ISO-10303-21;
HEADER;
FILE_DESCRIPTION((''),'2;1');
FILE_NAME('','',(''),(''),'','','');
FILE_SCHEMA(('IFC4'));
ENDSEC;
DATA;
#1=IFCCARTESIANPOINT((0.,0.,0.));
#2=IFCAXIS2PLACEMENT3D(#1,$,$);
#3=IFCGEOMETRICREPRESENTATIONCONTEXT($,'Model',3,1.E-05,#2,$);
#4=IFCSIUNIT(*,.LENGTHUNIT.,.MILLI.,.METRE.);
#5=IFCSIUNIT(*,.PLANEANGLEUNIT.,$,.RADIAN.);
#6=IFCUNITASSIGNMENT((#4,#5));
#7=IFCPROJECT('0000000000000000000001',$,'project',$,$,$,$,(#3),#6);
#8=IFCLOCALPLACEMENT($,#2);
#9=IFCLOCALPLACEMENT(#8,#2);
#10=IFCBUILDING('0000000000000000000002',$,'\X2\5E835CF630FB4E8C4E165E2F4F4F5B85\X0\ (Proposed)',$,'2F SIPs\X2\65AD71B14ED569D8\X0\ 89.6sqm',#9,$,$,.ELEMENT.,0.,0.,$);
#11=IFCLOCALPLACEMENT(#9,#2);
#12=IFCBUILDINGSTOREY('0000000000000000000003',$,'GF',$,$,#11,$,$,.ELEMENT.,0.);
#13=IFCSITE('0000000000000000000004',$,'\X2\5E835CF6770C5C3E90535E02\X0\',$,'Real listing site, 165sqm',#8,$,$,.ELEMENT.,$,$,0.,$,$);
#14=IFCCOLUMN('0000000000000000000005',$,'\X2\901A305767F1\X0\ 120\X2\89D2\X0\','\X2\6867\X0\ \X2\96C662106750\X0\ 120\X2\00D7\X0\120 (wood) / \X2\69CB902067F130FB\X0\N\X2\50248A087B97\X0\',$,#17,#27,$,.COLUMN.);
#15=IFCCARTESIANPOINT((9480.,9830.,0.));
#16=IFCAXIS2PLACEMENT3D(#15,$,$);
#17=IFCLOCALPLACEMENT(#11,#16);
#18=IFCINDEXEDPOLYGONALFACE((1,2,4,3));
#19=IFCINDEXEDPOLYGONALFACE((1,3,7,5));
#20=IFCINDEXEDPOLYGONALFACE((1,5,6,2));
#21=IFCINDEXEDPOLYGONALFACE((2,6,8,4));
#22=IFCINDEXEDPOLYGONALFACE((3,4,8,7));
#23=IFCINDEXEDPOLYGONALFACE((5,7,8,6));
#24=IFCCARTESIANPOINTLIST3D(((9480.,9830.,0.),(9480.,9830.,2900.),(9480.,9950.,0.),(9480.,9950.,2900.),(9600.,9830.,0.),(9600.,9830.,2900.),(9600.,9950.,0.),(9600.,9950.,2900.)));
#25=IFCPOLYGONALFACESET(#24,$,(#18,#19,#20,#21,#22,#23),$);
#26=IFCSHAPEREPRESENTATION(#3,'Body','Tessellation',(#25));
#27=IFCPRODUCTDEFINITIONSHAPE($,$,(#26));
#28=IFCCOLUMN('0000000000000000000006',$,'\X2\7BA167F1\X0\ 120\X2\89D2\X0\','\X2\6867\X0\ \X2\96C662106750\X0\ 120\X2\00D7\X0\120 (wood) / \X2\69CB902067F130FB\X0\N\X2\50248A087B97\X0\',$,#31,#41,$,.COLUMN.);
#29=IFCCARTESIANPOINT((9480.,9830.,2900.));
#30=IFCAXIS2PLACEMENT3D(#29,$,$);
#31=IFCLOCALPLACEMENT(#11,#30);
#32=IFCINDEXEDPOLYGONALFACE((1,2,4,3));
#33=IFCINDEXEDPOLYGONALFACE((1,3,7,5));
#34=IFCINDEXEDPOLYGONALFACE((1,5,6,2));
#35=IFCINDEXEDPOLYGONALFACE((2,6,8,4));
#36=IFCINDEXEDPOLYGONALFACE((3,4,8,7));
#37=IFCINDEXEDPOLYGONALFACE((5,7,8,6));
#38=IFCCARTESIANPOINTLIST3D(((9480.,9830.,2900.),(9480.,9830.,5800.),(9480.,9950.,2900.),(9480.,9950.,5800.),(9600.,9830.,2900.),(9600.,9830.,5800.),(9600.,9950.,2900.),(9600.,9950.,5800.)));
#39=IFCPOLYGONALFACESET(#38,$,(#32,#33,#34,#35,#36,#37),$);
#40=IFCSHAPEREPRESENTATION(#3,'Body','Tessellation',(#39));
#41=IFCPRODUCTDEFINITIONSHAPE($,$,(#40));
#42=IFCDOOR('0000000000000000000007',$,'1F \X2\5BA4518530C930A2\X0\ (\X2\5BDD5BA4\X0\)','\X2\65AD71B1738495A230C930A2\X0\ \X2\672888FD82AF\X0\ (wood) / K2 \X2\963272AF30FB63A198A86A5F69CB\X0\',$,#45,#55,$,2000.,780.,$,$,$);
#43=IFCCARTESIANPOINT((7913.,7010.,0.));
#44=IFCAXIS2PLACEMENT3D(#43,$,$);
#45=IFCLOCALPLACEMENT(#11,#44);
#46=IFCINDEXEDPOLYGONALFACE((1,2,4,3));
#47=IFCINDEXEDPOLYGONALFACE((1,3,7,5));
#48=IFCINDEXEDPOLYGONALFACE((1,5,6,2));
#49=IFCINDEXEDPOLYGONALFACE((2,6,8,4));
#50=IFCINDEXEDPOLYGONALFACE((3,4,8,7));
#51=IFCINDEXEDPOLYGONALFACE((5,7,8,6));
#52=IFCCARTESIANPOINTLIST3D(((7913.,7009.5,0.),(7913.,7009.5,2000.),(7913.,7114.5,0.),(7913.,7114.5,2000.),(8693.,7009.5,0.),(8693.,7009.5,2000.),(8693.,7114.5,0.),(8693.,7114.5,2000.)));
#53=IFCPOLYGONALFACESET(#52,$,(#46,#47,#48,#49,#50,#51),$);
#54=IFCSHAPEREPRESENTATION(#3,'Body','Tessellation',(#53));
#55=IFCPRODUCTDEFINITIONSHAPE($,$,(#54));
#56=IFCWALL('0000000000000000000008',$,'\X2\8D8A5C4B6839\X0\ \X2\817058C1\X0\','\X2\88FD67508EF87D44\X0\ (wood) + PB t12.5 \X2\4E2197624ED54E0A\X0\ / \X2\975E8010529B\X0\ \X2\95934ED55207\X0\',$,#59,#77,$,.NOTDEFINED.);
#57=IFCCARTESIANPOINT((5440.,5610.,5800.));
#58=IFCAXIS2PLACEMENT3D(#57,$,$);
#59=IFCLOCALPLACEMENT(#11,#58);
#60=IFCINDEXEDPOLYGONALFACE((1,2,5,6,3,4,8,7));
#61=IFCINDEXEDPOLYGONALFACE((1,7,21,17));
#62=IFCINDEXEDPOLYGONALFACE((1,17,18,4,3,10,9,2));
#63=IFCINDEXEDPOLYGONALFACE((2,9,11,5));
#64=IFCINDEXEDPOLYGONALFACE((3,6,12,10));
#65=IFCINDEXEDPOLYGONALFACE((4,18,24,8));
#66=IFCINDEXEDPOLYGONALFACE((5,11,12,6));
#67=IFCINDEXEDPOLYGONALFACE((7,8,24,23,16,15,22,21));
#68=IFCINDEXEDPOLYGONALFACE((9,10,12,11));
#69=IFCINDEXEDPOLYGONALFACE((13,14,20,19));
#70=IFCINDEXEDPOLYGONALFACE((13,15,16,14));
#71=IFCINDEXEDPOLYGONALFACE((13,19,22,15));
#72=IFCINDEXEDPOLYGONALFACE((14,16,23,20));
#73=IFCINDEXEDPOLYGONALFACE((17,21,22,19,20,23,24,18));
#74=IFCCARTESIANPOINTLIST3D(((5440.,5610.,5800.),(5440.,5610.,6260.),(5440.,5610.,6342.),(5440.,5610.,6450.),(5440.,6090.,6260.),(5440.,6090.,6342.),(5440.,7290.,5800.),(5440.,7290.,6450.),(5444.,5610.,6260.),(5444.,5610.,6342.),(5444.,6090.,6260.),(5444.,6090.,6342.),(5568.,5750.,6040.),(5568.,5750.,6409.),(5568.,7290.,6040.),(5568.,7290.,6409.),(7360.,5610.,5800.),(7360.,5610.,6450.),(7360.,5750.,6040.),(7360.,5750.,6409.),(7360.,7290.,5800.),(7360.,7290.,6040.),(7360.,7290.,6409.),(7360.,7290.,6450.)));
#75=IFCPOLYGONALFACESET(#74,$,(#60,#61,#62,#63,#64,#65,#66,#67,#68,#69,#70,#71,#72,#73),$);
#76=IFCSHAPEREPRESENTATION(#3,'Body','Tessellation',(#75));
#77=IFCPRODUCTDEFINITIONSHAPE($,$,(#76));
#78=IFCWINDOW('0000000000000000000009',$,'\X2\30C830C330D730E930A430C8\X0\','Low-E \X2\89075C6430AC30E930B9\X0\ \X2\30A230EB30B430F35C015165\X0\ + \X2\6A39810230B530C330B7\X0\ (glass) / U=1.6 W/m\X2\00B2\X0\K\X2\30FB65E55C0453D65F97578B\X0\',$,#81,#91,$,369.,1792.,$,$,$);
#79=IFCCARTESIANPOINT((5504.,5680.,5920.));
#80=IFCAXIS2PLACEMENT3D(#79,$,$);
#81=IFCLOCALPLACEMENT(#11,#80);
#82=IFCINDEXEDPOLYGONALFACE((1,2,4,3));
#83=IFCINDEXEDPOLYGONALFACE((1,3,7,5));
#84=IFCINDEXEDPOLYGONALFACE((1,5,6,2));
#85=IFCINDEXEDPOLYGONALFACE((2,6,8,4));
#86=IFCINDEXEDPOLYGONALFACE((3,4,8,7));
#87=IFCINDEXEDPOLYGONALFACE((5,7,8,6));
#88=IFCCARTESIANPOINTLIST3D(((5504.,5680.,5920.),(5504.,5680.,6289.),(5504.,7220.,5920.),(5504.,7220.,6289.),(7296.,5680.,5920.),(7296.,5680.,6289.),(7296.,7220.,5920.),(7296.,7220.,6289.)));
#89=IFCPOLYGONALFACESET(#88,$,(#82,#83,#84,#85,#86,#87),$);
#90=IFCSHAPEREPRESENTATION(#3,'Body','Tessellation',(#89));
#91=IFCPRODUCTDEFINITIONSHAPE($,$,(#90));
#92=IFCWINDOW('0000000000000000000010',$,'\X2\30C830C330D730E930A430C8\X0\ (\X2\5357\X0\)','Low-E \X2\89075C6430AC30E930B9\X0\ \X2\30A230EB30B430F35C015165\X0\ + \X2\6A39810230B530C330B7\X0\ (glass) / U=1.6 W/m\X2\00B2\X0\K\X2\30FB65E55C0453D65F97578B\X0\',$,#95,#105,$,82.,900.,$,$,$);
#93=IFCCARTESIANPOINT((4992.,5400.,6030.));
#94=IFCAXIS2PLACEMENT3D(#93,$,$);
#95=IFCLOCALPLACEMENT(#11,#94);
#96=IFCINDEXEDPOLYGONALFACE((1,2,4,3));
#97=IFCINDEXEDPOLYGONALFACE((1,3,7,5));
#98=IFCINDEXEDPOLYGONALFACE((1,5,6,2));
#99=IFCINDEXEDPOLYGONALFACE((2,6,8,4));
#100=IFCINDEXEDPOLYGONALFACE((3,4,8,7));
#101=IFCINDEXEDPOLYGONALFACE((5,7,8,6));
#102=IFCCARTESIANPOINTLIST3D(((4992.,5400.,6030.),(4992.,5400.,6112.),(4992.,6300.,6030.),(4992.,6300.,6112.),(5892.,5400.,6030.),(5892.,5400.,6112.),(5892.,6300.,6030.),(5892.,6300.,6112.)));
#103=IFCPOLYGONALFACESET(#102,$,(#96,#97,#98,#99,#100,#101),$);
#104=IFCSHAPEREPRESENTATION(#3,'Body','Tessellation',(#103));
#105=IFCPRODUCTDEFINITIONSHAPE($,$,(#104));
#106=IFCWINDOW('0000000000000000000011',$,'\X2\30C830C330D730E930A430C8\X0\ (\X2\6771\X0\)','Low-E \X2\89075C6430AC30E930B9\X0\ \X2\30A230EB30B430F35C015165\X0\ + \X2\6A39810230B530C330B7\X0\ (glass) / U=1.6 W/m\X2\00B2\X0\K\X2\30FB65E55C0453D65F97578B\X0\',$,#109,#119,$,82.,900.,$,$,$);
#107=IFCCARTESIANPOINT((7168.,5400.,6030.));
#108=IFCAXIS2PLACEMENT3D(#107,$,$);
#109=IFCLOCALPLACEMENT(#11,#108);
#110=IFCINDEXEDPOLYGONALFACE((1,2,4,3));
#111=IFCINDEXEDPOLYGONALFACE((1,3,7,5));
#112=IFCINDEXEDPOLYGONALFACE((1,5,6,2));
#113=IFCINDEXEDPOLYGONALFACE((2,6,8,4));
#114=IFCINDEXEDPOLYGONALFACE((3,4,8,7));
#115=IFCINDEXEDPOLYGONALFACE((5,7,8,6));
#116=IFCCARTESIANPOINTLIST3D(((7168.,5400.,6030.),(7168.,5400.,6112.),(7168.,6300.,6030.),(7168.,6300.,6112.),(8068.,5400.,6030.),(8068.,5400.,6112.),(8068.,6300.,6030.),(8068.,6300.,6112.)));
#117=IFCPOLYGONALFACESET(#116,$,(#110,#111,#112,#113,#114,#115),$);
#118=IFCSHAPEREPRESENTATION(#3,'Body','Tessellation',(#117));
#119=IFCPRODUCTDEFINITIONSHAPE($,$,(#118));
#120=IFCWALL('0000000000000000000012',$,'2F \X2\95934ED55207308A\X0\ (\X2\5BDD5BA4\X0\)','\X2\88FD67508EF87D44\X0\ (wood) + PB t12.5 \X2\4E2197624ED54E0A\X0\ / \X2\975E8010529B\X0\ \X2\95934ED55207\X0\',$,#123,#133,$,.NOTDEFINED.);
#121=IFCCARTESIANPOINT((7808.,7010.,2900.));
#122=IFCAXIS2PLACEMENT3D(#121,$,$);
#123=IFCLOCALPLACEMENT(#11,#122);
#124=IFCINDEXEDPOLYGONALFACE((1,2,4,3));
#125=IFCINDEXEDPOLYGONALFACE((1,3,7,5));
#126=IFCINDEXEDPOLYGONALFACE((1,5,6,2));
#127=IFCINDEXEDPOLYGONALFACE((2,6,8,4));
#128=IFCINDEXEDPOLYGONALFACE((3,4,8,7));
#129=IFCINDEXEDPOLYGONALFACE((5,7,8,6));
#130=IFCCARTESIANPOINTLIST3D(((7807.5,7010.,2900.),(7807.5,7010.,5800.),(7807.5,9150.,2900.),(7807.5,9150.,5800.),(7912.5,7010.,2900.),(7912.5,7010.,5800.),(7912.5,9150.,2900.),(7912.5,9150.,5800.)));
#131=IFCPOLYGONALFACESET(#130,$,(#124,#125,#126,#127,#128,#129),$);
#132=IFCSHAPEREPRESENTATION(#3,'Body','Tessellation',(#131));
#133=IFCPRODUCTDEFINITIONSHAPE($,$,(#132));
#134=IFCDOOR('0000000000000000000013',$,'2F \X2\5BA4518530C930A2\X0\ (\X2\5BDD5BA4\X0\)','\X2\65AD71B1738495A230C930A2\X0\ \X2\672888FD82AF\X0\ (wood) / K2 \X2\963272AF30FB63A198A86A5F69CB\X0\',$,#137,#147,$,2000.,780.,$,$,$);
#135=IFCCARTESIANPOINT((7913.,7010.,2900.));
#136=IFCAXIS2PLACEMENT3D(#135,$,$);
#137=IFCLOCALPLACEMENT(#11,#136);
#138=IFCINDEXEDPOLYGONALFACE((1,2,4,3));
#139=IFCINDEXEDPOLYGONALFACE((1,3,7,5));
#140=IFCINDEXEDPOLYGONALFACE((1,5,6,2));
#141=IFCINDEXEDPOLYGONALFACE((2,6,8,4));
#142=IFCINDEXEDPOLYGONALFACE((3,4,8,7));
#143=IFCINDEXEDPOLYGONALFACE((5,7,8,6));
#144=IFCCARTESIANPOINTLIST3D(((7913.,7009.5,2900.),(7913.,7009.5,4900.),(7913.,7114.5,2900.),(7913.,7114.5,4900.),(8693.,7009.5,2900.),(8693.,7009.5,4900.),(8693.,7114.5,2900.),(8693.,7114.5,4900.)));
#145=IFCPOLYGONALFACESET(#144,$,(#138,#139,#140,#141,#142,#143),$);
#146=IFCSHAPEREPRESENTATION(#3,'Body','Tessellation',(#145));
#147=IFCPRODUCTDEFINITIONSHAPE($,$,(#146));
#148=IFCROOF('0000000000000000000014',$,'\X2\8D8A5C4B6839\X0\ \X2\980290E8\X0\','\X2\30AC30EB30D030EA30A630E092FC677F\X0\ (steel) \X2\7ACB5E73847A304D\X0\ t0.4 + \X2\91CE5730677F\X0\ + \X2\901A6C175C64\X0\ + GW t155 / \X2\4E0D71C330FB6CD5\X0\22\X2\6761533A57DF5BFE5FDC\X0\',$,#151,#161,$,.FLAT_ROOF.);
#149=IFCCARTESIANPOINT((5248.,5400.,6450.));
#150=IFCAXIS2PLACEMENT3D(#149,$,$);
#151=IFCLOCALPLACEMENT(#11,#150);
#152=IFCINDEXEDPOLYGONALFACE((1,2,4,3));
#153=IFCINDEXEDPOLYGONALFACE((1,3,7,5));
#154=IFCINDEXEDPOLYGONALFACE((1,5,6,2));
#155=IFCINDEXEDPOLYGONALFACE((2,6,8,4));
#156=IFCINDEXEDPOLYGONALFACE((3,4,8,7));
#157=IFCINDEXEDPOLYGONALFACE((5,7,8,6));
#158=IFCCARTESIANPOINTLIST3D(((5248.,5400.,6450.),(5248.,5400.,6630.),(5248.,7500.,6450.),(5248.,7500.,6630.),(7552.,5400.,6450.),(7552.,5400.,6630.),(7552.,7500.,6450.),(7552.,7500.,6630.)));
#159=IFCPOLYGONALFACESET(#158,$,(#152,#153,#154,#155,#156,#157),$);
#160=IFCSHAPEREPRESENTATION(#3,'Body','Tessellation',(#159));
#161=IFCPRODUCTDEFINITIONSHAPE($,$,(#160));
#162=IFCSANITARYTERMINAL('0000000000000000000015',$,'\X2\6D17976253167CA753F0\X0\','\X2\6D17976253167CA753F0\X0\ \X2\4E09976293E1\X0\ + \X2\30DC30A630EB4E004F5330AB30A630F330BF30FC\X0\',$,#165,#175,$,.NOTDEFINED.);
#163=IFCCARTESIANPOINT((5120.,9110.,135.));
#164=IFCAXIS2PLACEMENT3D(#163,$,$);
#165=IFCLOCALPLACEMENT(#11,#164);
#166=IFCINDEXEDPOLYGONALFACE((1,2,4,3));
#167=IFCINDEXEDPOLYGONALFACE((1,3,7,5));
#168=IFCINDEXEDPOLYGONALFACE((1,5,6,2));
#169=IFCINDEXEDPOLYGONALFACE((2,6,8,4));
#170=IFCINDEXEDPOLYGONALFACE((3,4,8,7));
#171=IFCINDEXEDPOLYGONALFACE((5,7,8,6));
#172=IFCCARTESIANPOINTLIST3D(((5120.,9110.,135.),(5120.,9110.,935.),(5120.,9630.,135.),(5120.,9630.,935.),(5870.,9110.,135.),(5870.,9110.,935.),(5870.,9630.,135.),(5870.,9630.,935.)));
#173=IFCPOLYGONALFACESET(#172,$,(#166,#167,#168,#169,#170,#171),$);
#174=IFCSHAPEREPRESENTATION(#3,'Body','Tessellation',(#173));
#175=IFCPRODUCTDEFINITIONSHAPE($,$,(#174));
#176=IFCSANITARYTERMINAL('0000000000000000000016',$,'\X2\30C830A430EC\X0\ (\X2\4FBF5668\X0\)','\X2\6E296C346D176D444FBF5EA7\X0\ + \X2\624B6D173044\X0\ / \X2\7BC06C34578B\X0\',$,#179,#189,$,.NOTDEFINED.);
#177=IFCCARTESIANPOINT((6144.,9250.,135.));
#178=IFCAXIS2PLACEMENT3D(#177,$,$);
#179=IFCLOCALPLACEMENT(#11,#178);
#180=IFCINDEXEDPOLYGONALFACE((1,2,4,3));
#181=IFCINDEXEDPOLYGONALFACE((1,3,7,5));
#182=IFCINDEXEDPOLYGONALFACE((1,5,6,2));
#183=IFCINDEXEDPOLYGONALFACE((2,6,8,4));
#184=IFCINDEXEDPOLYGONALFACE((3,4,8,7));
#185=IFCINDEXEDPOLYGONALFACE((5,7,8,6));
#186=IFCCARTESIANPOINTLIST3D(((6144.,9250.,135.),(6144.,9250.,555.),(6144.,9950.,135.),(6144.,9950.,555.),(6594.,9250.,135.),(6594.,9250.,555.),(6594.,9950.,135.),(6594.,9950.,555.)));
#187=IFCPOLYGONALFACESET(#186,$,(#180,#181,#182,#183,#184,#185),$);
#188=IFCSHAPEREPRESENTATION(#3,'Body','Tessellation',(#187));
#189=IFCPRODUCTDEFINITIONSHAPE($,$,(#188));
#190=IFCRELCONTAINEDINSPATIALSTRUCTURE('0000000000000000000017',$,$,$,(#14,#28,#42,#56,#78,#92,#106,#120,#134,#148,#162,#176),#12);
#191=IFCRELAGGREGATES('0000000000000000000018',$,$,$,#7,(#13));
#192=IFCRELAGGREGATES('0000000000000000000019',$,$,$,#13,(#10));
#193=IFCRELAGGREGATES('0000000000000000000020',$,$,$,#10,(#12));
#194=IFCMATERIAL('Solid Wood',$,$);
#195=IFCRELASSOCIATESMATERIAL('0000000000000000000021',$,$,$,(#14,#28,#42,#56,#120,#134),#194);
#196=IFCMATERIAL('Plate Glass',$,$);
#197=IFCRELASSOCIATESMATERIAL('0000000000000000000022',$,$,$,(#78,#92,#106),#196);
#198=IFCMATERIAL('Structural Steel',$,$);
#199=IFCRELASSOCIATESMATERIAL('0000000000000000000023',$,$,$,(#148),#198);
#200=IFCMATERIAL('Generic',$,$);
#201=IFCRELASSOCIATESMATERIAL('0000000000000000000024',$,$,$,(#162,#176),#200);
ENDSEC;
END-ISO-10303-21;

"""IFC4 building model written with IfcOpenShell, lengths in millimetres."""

from ifc_helpers import new_model, si_unit, frame, frame_2d, origin, place, context, project, spatial, rectangle, extrude, material, element, fill, save


model = new_model("IFC4")

# Units and contexts
model_context = context("Model", 3, precision=1e-05, world=origin())
ifc_project = project(units=[si_unit("LENGTHUNIT", "METRE", prefix="MILLI"), si_unit("PLANEANGLEUNIT", "RADIAN")], contexts=[model_context])

# Site, building, storey
site_placement = place(None, origin())
site = spatial("IfcSite", under=ifc_project, at=site_placement, Name="広島県尾道市", ObjectType="Real listing site, 165sqm", CompositionType="ELEMENT", RefElevation=0.0)
building_placement = place(site_placement, origin())
building = spatial("IfcBuilding", under=site, at=building_placement, Name="広島・二世帯住宅 (Proposed)", ObjectType="2F SIPs断熱仕様 89.6sqm", CompositionType="ELEMENT", ElevationOfRefHeight=0.0, ElevationOfTerrain=0.0)
storey_placement = place(building_placement, origin())
storey = spatial("IfcBuildingStorey", under=building, at=storey_placement, Name="GF", CompositionType="ELEMENT", Elevation=0.0)

# Columns
ifc_material_1 = material(Name="Solid Wood")
column_1_placement = place(storey_placement, frame((9480.0, 9830.0, 0.0)))
element("IfcColumn", 1, at=column_1_placement, inside=storey, material=ifc_material_1, Name="通し柱 120角", Description="桧 集成材 120×120 (wood) / 構造柱・N値計算", PredefinedType="COLUMN", context=model_context, shape_type="SweptSolid", body=[
    extrude(rectangle(XDim=120.0, YDim=120.0, at=frame_2d((60.0, 60.0))), frame((9480.0, 9830.0, 0.0)), (0.0, 0.0, 1.0), 2900.0),
])
column_2_placement = place(storey_placement, frame((9480.0, 9830.0, 2900.0)))
element("IfcColumn", 2, at=column_2_placement, inside=storey, material=ifc_material_1, Name="管柱 120角", Description="桧 集成材 120×120 (wood) / 構造柱・N値計算", PredefinedType="COLUMN", context=model_context, shape_type="SweptSolid", body=[
    extrude(rectangle(XDim=120.0, YDim=120.0, at=frame_2d((60.0, 60.0))), frame((9480.0, 9830.0, 2900.0)), (0.0, 0.0, 1.0), 2900.0),
])

# Door
door_1_placement = place(storey_placement, frame((7913.0, 7010.0, 0.0)))
element("IfcDoor", 3, at=door_1_placement, inside=storey, material=ifc_material_1, Name="1F 室内ドア (寝室)", Description="断熱玄関ドア 木製芯 (wood) / K2 防犯・採風機構", OverallHeight=2000.0, OverallWidth=780.0, context=model_context, shape_type="SweptSolid", body=[
    extrude(rectangle(XDim=780.0, YDim=105.0, at=frame_2d((390.0, 52.0))), frame((7913.0, 7010.0, 0.0)), (0.0, 0.0, 1.0), 2000.0),
])

# Wall, openings, windows
wall_1_placement = place(storey_placement, frame((5440.0, 5610.0, 5800.0)))
wall_1 = element("IfcWall", 4, at=wall_1_placement, inside=storey, material=ifc_material_1, Name="越屋根 腰壁", Description="製材軸組 (wood) + PB t12.5 両面仕上 / 非耐力 間仕切", PredefinedType="NOTDEFINED", context=model_context, shape_type="SweptSolid", body=[
    extrude(rectangle(XDim=1920.0, YDim=1680.0, at=frame_2d((960.0, 840.0))), frame((5440.0, 5610.0, 5800.0)), (0.0, 0.0, 1.0), 650.0),
])
opening_1_placement = place(storey_placement, frame((5504.0, 5680.0, 5920.0)))
opening_1 = element("IfcOpeningElement", 5, at=opening_1_placement, cuts=wall_1, PredefinedType="NOTDEFINED", context=model_context, shape_type="SweptSolid", body=[
    extrude(rectangle(XDim=1792.0, YDim=1540.0, at=frame_2d((896.0, 770.0))), frame((5504.0, 5680.0, 5920.0)), (0.0, 0.0, 1.0), 369.0),
])
opening_2_placement = place(storey_placement, frame((4992.0, 5400.0, 6030.0)))
opening_2 = element("IfcOpeningElement", 6, at=opening_2_placement, cuts=wall_1, PredefinedType="NOTDEFINED", context=model_context, shape_type="SweptSolid", body=[
    extrude(rectangle(XDim=900.0, YDim=900.0, at=frame_2d((450.0, 450.0))), frame((4992.0, 5400.0, 6030.0)), (0.0, 0.0, 1.0), 82.0),
])
opening_3_placement = place(storey_placement, frame((7168.0, 5400.0, 6030.0)))
opening_3 = element("IfcOpeningElement", 7, at=opening_3_placement, cuts=wall_1, PredefinedType="NOTDEFINED", context=model_context, shape_type="SweptSolid", body=[
    extrude(rectangle(XDim=900.0, YDim=900.0, at=frame_2d((450.0, 450.0))), frame((7168.0, 5400.0, 6030.0)), (0.0, 0.0, 1.0), 82.0),
])
ifc_material_2 = material(Name="Plate Glass")
window_1_placement = place(storey_placement, frame((5504.0, 5680.0, 5920.0)))
window_1 = element("IfcWindow", 8, at=window_1_placement, inside=storey, material=ifc_material_2, Name="トップライト", Description="Low-E 複層ガラス アルゴン封入 + 樹脂サッシ (glass) / U=1.6 W/m²K・日射取得型", OverallHeight=369.0, OverallWidth=1792.0, context=model_context, shape_type="SweptSolid", body=[
    extrude(rectangle(XDim=1792.0, YDim=1540.0, at=frame_2d((896.0, 770.0))), frame((5504.0, 5680.0, 5920.0)), (0.0, 0.0, 1.0), 369.0),
])
fill(opening_1, window_1)
window_2_placement = place(storey_placement, frame((4992.0, 5400.0, 6030.0)))
window_2 = element("IfcWindow", 9, at=window_2_placement, inside=storey, material=ifc_material_2, Name="トップライト (南)", Description="Low-E 複層ガラス アルゴン封入 + 樹脂サッシ (glass) / U=1.6 W/m²K・日射取得型", OverallHeight=82.0, OverallWidth=900.0, context=model_context, shape_type="SweptSolid", body=[
    extrude(rectangle(XDim=900.0, YDim=900.0, at=frame_2d((450.0, 450.0))), frame((4992.0, 5400.0, 6030.0)), (0.0, 0.0, 1.0), 82.0),
])
fill(opening_2, window_2)
window_3_placement = place(storey_placement, frame((7168.0, 5400.0, 6030.0)))
window_3 = element("IfcWindow", 10, at=window_3_placement, inside=storey, material=ifc_material_2, Name="トップライト (東)", Description="Low-E 複層ガラス アルゴン封入 + 樹脂サッシ (glass) / U=1.6 W/m²K・日射取得型", OverallHeight=82.0, OverallWidth=900.0, context=model_context, shape_type="SweptSolid", body=[
    extrude(rectangle(XDim=900.0, YDim=900.0, at=frame_2d((450.0, 450.0))), frame((7168.0, 5400.0, 6030.0)), (0.0, 0.0, 1.0), 82.0),
])
fill(opening_3, window_3)

# Wall
wall_2_placement = place(storey_placement, frame((7808.0, 7010.0, 2900.0)))
element("IfcWall", 11, at=wall_2_placement, inside=storey, material=ifc_material_1, Name="2F 間仕切り (寝室)", Description="製材軸組 (wood) + PB t12.5 両面仕上 / 非耐力 間仕切", PredefinedType="NOTDEFINED", context=model_context, shape_type="SweptSolid", body=[
    extrude(rectangle(XDim=105.0, YDim=2140.0, at=frame_2d((52.0, 1070.0))), frame((7808.0, 7010.0, 2900.0)), (0.0, 0.0, 1.0), 2900.0),
])

# Door
door_2_placement = place(storey_placement, frame((7913.0, 7010.0, 2900.0)))
element("IfcDoor", 12, at=door_2_placement, inside=storey, material=ifc_material_1, Name="2F 室内ドア (寝室)", Description="断熱玄関ドア 木製芯 (wood) / K2 防犯・採風機構", OverallHeight=2000.0, OverallWidth=780.0, context=model_context, shape_type="SweptSolid", body=[
    extrude(rectangle(XDim=780.0, YDim=105.0, at=frame_2d((390.0, 52.0))), frame((7913.0, 7010.0, 2900.0)), (0.0, 0.0, 1.0), 2000.0),
])

# Roof
ifc_material_3 = material(Name="Structural Steel")
roof_placement = place(storey_placement, frame((5248.0, 5400.0, 6450.0)))
element("IfcRoof", 13, at=roof_placement, inside=storey, material=ifc_material_3, Name="越屋根 頂部", Description="ガルバリウム鋼板 (steel) 立平葺き t0.4 + 野地板 + 通気層 + GW t155 / 不燃・法22条区域対応", PredefinedType="FLAT_ROOF", context=model_context, shape_type="SweptSolid", body=[
    extrude(rectangle(XDim=2304.0, YDim=2100.0, at=frame_2d((1152.0, 1050.0))), frame((5248.0, 5400.0, 6450.0)), (0.0, 0.0, 1.0), 180.0),
])

# Sanitary terminals
ifc_material_4 = material(Name="Generic")
sanitary_terminal_1_placement = place(storey_placement, frame((5120.0, 9110.0, 135.0)))
element("IfcSanitaryTerminal", 14, at=sanitary_terminal_1_placement, inside=storey, material=ifc_material_4, Name="洗面化粧台", Description="洗面化粧台 三面鏡 + ボウル一体カウンター", PredefinedType="NOTDEFINED", context=model_context, shape_type="SweptSolid", body=[
    extrude(rectangle(XDim=750.0, YDim=520.0, at=frame_2d((375.0, 260.0))), frame((5120.0, 9110.0, 135.0)), (0.0, 0.0, 1.0), 800.0),
])
sanitary_terminal_2_placement = place(storey_placement, frame((6144.0, 9250.0, 135.0)))
element("IfcSanitaryTerminal", 15, at=sanitary_terminal_2_placement, inside=storey, material=ifc_material_4, Name="トイレ (便器)", Description="温水洗浄便座 + 手洗い / 節水型", PredefinedType="NOTDEFINED", context=model_context, shape_type="SweptSolid", body=[
    extrude(rectangle(XDim=450.0, YDim=700.0, at=frame_2d((225.0, 350.0))), frame((6144.0, 9250.0, 135.0)), (0.0, 0.0, 1.0), 420.0),
])

save(model, "model.ifc")
